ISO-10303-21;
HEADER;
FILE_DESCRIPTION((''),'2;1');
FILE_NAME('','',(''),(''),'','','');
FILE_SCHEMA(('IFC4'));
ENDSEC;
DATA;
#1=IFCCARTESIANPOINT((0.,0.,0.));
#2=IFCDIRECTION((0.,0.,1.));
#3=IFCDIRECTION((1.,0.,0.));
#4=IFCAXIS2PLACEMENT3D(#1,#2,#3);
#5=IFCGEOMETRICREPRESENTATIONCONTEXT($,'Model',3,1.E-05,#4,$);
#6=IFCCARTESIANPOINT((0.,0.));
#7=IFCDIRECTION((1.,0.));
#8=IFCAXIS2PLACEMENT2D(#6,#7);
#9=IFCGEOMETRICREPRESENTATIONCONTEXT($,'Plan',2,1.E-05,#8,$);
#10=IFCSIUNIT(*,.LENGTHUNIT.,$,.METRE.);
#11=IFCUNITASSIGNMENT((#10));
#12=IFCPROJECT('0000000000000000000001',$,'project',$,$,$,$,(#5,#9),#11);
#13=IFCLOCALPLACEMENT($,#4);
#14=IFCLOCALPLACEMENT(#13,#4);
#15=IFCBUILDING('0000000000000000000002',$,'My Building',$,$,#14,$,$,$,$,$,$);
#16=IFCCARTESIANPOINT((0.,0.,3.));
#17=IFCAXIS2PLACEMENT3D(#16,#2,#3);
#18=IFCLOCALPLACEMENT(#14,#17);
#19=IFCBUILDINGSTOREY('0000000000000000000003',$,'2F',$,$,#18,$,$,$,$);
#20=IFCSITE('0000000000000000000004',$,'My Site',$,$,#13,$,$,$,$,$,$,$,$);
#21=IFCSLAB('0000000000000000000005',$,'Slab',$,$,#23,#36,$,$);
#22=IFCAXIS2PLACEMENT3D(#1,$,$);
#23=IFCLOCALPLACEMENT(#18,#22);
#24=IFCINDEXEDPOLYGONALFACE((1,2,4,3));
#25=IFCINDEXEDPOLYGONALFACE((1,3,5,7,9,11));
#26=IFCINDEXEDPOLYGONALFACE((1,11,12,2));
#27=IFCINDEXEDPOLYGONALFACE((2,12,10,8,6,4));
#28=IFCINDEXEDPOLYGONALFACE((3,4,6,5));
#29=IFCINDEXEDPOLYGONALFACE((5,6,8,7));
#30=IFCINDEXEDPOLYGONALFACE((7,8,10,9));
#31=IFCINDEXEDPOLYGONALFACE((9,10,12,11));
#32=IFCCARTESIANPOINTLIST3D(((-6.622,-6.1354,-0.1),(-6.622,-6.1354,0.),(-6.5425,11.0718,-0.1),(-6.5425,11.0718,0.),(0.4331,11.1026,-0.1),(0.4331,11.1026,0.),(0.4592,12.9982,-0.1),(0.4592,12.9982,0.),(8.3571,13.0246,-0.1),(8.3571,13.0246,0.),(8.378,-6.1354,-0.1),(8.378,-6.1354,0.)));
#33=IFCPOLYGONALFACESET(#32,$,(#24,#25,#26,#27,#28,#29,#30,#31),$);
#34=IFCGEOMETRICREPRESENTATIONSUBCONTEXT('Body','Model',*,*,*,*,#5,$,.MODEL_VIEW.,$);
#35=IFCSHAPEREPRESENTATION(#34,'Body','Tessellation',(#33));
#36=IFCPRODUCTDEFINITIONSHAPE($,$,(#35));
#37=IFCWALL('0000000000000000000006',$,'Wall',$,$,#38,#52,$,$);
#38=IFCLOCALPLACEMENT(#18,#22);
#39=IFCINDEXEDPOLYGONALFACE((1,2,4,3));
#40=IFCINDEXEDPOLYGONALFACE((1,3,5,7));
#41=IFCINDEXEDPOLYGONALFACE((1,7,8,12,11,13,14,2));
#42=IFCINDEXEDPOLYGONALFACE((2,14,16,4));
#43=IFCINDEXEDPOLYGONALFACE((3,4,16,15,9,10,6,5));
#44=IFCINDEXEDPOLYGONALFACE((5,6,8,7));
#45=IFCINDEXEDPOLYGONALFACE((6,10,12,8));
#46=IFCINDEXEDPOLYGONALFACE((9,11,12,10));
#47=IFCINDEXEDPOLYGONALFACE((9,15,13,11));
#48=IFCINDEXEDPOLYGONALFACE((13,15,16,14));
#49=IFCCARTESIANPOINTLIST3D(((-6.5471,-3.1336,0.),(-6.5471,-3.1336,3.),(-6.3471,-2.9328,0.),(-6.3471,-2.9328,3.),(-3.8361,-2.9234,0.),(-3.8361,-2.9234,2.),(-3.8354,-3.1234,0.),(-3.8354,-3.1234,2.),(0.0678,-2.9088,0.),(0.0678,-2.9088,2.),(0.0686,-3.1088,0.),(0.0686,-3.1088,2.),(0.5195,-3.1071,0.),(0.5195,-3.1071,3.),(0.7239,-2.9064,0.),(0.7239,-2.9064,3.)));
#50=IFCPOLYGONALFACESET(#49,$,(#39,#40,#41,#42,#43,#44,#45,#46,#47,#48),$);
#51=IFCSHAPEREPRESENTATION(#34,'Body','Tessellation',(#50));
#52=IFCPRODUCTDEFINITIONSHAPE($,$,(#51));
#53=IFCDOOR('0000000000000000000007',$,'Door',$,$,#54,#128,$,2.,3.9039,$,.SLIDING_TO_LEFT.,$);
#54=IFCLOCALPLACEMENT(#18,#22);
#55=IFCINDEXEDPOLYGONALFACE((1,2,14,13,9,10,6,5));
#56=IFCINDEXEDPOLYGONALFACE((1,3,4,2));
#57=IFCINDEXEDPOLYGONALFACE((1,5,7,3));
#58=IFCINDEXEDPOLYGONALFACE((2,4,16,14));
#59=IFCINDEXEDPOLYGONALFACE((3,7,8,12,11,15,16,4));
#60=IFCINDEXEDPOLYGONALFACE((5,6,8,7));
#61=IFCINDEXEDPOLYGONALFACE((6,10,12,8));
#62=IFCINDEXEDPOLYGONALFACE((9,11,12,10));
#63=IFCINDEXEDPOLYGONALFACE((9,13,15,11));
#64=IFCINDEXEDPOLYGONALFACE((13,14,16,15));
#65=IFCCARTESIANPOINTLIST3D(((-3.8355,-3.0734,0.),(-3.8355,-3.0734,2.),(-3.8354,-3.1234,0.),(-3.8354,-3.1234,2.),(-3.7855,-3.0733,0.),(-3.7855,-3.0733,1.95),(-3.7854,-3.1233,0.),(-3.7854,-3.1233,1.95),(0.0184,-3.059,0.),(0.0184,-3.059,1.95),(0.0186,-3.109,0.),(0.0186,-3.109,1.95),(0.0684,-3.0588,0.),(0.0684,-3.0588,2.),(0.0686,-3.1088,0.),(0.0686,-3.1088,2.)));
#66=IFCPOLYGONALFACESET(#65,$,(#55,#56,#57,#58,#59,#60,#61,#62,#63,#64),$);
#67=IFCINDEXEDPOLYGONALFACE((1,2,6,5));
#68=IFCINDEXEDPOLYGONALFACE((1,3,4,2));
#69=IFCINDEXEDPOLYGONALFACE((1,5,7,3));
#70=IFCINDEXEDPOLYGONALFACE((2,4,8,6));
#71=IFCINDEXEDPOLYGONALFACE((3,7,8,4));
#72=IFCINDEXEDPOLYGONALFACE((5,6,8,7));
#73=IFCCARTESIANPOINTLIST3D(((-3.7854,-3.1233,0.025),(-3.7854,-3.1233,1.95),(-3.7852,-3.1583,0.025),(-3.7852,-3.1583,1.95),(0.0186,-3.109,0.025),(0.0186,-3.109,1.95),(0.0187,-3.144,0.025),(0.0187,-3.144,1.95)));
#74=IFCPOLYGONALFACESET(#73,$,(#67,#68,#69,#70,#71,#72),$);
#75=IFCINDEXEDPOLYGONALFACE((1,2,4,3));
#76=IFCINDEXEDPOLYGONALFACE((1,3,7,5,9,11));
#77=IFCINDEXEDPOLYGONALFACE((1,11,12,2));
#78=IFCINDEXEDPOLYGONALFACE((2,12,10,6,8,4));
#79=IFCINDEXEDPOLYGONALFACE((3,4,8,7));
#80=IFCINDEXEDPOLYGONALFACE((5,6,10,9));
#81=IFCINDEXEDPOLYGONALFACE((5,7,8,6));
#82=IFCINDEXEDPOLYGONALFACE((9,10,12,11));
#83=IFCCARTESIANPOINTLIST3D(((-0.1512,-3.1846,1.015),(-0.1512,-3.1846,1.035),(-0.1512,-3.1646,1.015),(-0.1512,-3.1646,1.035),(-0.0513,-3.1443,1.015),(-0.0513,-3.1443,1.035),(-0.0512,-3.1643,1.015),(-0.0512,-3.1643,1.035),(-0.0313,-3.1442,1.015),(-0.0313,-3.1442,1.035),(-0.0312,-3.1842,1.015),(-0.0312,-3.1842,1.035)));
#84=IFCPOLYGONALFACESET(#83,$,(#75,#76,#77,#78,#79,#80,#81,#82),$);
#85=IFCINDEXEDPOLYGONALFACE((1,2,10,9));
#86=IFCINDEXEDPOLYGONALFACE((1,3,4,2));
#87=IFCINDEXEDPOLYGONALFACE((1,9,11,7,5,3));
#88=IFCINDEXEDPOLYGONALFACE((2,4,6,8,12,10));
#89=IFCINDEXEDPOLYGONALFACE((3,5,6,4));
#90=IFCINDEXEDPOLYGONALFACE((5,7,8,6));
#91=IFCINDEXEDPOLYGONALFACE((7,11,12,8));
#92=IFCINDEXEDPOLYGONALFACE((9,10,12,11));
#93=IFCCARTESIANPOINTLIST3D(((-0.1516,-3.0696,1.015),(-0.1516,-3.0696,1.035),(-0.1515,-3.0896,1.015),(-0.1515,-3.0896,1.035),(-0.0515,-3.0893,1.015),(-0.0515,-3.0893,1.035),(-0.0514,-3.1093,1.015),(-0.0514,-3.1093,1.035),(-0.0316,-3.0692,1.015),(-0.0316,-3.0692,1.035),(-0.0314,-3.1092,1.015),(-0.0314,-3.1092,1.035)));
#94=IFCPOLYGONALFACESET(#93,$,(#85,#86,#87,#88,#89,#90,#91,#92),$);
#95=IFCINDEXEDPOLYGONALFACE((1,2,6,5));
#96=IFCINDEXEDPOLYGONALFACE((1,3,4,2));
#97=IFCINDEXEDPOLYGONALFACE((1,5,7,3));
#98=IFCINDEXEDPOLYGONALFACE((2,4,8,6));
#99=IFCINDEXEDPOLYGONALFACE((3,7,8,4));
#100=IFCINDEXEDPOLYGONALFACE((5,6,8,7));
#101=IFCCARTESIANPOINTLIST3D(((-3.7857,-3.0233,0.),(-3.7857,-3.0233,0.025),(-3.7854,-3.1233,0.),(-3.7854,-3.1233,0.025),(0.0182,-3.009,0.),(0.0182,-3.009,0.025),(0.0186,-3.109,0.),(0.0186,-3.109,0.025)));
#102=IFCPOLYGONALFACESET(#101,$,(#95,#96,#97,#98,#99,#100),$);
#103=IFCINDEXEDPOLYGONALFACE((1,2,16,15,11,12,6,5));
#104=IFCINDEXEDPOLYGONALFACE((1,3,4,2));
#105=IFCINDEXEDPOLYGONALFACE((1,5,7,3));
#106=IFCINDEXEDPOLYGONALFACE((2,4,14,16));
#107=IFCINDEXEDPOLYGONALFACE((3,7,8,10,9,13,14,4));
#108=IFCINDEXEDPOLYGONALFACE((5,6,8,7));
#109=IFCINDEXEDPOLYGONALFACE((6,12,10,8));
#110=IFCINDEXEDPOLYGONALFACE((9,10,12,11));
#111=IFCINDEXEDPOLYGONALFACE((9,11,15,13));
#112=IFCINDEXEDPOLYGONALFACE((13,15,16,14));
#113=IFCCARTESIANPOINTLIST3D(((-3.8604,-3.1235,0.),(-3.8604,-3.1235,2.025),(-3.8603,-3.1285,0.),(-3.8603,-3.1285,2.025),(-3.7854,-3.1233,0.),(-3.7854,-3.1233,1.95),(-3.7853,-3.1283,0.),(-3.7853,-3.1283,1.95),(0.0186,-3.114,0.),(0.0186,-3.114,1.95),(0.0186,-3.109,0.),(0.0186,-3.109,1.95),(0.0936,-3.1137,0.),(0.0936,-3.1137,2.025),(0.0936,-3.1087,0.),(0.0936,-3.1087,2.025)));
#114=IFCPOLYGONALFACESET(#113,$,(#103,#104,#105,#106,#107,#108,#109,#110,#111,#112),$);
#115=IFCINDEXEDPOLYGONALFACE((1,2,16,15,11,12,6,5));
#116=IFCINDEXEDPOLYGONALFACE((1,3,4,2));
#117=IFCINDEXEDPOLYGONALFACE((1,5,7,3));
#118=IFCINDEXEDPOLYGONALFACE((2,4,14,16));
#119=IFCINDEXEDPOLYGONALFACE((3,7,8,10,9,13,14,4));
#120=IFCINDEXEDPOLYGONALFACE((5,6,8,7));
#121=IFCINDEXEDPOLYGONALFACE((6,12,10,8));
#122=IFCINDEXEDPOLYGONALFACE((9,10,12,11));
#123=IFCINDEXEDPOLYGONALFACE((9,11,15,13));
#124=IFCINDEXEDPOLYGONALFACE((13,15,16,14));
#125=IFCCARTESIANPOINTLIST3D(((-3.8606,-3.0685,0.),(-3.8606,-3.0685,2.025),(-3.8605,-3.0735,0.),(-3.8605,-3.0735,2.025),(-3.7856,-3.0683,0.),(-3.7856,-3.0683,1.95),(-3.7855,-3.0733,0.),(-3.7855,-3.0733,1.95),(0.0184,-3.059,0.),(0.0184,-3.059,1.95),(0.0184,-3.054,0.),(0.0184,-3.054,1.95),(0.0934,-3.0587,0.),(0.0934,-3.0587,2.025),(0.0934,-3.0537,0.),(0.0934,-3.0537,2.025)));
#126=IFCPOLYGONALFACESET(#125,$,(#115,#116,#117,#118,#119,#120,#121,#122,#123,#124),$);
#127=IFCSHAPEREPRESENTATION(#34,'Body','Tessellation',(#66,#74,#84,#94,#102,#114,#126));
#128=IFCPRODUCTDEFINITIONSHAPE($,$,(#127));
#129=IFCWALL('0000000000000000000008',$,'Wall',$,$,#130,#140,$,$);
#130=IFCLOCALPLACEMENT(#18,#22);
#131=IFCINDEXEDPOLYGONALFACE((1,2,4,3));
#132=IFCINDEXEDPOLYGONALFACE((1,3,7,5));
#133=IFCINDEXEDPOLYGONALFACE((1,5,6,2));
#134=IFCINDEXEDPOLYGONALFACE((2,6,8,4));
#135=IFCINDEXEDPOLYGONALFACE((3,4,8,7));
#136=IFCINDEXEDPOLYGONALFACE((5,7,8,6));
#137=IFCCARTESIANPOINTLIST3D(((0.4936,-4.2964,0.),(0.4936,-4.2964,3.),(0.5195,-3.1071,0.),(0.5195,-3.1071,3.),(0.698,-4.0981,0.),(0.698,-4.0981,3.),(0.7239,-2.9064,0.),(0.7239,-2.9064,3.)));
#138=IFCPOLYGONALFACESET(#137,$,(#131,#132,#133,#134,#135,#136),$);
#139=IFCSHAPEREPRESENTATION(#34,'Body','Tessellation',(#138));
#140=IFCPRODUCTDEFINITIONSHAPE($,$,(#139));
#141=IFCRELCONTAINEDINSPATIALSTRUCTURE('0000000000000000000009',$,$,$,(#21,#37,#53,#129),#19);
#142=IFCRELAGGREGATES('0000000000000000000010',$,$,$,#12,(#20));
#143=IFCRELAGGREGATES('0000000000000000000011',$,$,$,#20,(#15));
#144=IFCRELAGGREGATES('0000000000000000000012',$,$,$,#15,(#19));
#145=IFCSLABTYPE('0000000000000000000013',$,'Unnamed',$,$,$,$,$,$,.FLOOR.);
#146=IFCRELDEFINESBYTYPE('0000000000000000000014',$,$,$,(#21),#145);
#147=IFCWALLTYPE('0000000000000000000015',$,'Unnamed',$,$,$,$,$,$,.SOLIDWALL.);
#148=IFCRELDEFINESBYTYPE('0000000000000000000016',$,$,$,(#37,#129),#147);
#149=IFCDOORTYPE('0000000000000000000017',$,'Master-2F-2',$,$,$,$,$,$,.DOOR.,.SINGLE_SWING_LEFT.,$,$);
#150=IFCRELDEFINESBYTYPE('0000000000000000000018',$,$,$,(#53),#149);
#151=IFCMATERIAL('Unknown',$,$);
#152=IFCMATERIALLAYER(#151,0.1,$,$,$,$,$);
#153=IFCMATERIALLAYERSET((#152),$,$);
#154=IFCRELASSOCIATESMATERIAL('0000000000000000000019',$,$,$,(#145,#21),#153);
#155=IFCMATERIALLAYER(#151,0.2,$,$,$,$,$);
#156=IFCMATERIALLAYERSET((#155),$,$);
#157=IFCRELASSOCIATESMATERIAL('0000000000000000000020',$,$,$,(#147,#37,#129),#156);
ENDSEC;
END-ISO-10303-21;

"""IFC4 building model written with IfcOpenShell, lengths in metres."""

from ifc_helpers import new_model, entity, si_unit, frame, origin_with_axes, origin_2d_with_axis, place, context, subcontext, project, spatial, line, indexed_curve, outline, extrude, shape, source, transform, mapped, material, layer, layer_set, layer_usage, type_object, type_shapes, element, fill, save


model = new_model("IFC4")

# Units and contexts
model_context = context("Model", 3, precision=1e-05, world=origin_with_axes())
plan_context = context("Plan", 2, precision=1e-05, world=origin_2d_with_axis())
body_context_1 = subcontext(model_context, "Body", "Model", "MODEL_VIEW")
body_context_2 = subcontext(plan_context, "Body", "Plan", "PLAN_VIEW")
ifc_project = project(units=[si_unit("LENGTHUNIT", "METRE")], contexts=[model_context, plan_context])

# Site, building, storey
site_placement = place(None, origin_with_axes())
site = spatial("IfcSite", under=ifc_project, at=site_placement, Name="My Site")
building_placement = place(site_placement, origin_with_axes())
building = spatial("IfcBuilding", under=site, at=building_placement, Name="My Building")
storey_placement = place(building_placement, frame((0.0, 0.0, 3.0), z_axis=(0.0, 0.0, 1.0), x_axis=(1.0, 0.0, 0.0)))
storey = spatial("IfcBuildingStorey", under=building, at=storey_placement, Name="2F")

# Slab
ifc_material = material(Name="Unknown")
ifc_layer_1 = layer(ifc_material, 0.1)
ifc_layer_set_1 = layer_set([ifc_layer_1])
ifc_layer_usage_1 = layer_usage(ifc_layer_set_1, "AXIS3", "POSITIVE", -0.1)
slab_type = type_object("IfcSlabType", Name="Unnamed", PredefinedType="FLOOR", material=ifc_layer_set_1)
slab_placement = place(storey_placement, frame((8.378, -6.1354, 0.0), z_axis=(0.0, 0.0, 1.0), x_axis=(1.0, 0.0, 0.0)))
element("IfcSlab", 1, at=slab_placement, inside=storey, type_object=slab_type, material=ifc_layer_usage_1, Name="Slab", context=body_context_1, shape_type="SweptSolid", body=[
    extrude(outline(indexed_curve([(0.0, 0.0), (-15.0, 0.0), (-14.9205, 17.2072), (-7.9449, 17.238), (-7.9188, 19.1336), (-0.0209, 19.1599), (0.0, 0.0)])), frame((0.0, 0.0, -0.1), z_axis=(0.0, 0.0, 1.0), x_axis=(1.0, 0.0, 0.0)), (0.0, 0.0, 1.0), 0.1),
])

# Wall, opening, door
ifc_layer_2 = layer(ifc_material, 0.2)
ifc_layer_set_2 = layer_set([ifc_layer_2])
ifc_layer_usage_2 = layer_usage(ifc_layer_set_2, "AXIS2", "POSITIVE", 0.0)
wall_type = type_object("IfcWallType", Name="Unnamed", PredefinedType="SOLIDWALL", material=ifc_layer_set_2)
wall_1_placement = place(storey_placement, frame((-6.5471, -3.1336, 0.0), z_axis=(0.0, 0.0, 1.0), x_axis=(0.999993, 0.003745, 0.0)))
wall_1 = element("IfcWall", 2, at=wall_1_placement, inside=storey, type_object=wall_type, material=ifc_layer_usage_2, Name="Wall", context=body_context_1, shape_type="SweptSolid", body=[
    extrude(outline(indexed_curve([(0.0, 0.0), (0.2008, 0.2), (7.2718, 0.2), (7.0666, 0.0)], segments=[line(1, 2, 3, 4, 1)])), origin_with_axes(), (0.0, 0.0, 1.0), 3.0),
])
shared_shape_1 = source(origin_with_axes(), body_context_1, "Body", "SweptSolid", [
    extrude(outline(indexed_curve([(0.0, 0.0), (3.9039, 0.0), (3.9039, 2.0), (0.0, 2.0)], segments=[line(1, 2, 3, 4, 1)])), frame((0.0, -0.6, 0.0), z_axis=(0.0, -1.0, 0.0), x_axis=(1.0, 0.0, 0.0)), (0.0, 0.0, -1.0), 1.2),
])
opening_1_placement = place(wall_1_placement, frame((2.7118, 0.0, 0.0), z_axis=(0.0, 0.0, 1.0), x_axis=(1.0, 0.0, 0.0)))
opening_1 = element("IfcOpeningElement", 3, at=opening_1_placement, cuts=wall_1, PredefinedType="OPENING", context=body_context_1, shape_type="MappedRepresentation", body=[
    mapped(shared_shape_1, transform((0.0, 0.0, 0.0), x_axis=(1.0, 0.0, 0.0), y_axis=(0.0, 1.0, 0.0), z_axis=(0.0, 0.0, 1.0), scale=1.0)),
])
door_type_1 = type_object("IfcDoorType", Name="Master-2F-2", OperationType="SINGLE_SWING_LEFT", PredefinedType="DOOR")
shared_shape_2 = source(origin_with_axes(), body_context_1, "Body", "SweptSolid", [
    extrude(outline(indexed_curve([(0.0, 0.0), (0.0, 2.0), (3.9039, 2.0), (3.9039, 0.0), (3.8539, 0.0), (3.8539, 1.95), (0.05, 1.95), (0.05, 0.0)], segments=[line(1, 2, 3, 4, 5, 6, 7, 8, 1)])), frame((0.0, 0.0, 0.0), z_axis=(0.0, -1.0, 0.0), x_axis=(1.0, 0.0, 0.0)), (0.0, 0.0, -1.0), 0.05),
    extrude(outline(indexed_curve([(0.0, 0.0), (3.8039, 0.0), (3.8039, 0.035), (0.0, 0.035)], segments=[line(1, 2, 3, 4, 1)])), frame((0.05, -0.035, 0.025), z_axis=(0.0, 0.0, 1.0), x_axis=(1.0, 0.0, 0.0)), (0.0, 0.0, 1.0), 1.925),
    extrude(outline(indexed_curve([(0.0, 0.0), (0.0, -0.04), (-0.12, -0.04), (-0.12, -0.02), (-0.02, -0.02), (-0.02, 0.0)], segments=[line(1, 2, 3, 4, 5, 6, 1)])), frame((3.8039, -0.035, 1.015), z_axis=(0.0, 0.0, 1.0), x_axis=(1.0, 0.0, 0.0)), (0.0, 0.0, 1.0), 0.02),
    extrude(outline(indexed_curve([(0.0, 0.0), (0.0, 0.04), (-0.12, 0.04), (-0.12, 0.02), (-0.02, 0.02), (-0.02, 0.0)], segments=[line(1, 2, 3, 4, 5, 6, 1)])), frame((3.8039, 0.0, 1.015), z_axis=(0.0, 0.0, 1.0), x_axis=(1.0, 0.0, 0.0)), (0.0, 0.0, 1.0), 0.02),
    extrude(outline(indexed_curve([(0.0, 0.0), (3.8039, 0.0), (3.8039, 0.1), (0.0, 0.1)], segments=[line(1, 2, 3, 4, 1)])), frame((0.05, 0.0, 0.0), z_axis=(0.0, 0.0, 1.0), x_axis=(1.0, 0.0, 0.0)), (0.0, 0.0, 1.0), 0.025),
    extrude(outline(indexed_curve([(0.0, 0.0), (0.0, 2.025), (3.9539, 2.025), (3.9539, 0.0), (3.8789, 0.0), (3.8789, 1.95), (0.075, 1.95), (0.075, 0.0)], segments=[line(1, 2, 3, 4, 5, 6, 7, 8, 1)])), frame((-0.025, -0.005, 0.0), z_axis=(0.0, -1.0, 0.0), x_axis=(1.0, 0.0, 0.0)), (0.0, 0.0, -1.0), 0.005),
    extrude(outline(indexed_curve([(0.0, 0.0), (0.0, 2.025), (3.9539, 2.025), (3.9539, 0.0), (3.8789, 0.0), (3.8789, 1.95), (0.075, 1.95), (0.075, 0.0)], segments=[line(1, 2, 3, 4, 5, 6, 7, 8, 1)])), frame((-0.025, 0.05, 0.0), z_axis=(0.0, -1.0, 0.0), x_axis=(1.0, 0.0, 0.0)), (0.0, 0.0, -1.0), 0.005),
])
shared_shape_3 = source(origin_with_axes(), body_context_2, "Body", "Curve2D", [
    entity("IfcIndexedPolyCurve", entity("IfcCartesianPointList2D", [[0.0, 0.0], [0.05, 0.0], [0.05, 0.05], [0.0, 0.05]]), [entity("IfcLineIndex", [1, 2, 3, 4, 1])]),
    entity("IfcIndexedPolyCurve", entity("IfcCartesianPointList2D", [[3.9039, 0.0], [3.8539, 0.0], [3.8539, 0.05], [3.9039, 0.05]]), [entity("IfcLineIndex", [1, 2, 3, 4, 1])]),
    entity("IfcIndexedPolyCurve", entity("IfcCartesianPointList2D", [[-1.852, -0.035], [1.952, -0.035], [1.952, 0.0], [-1.852, 0.0]]), [entity("IfcLineIndex", [1, 2, 3, 4, 1])]),
])
type_shapes(door_type_1, [shared_shape_2, shared_shape_3])
door_1_placement = place(opening_1_placement, frame((0.0, 0.0, 0.0), z_axis=(0.0, 0.0, 1.0), x_axis=(1.0, 0.0, 0.0)))
door_1 = element("IfcDoor", 4, at=door_1_placement, inside=storey, type_object=door_type_1, Name="Door", OperationType="SLIDING_TO_LEFT", OverallHeight=2.0, OverallWidth=3.9039, shapes=[
    shape(body_context_1, "Body", "MappedRepresentation", [mapped(shared_shape_2, transform((0.0, 0.0, 0.0), x_axis=(1.0, 0.0, 0.0), y_axis=(0.0, 1.0, 0.0), z_axis=(0.0, 0.0, 1.0), scale=1.0))]),
    shape(body_context_2, "Body", "MappedRepresentation", [mapped(shared_shape_3, transform((0.0, 0.0, 0.0), x_axis=(1.0, 0.0, 0.0), y_axis=(0.0, 1.0, 0.0), z_axis=(0.0, 0.0, 1.0), scale=1.0))]),
])
fill(opening_1, door_1)

# Wall
ifc_layer_usage_3 = layer_usage(ifc_layer_set_2, "AXIS2", "POSITIVE", 0.0)
wall_2_placement = place(storey_placement, frame((0.5195, -3.1071, 0.0), z_axis=(0.0, 0.0, 1.0), x_axis=(-0.021734, -0.999764, 0.0)))
element("IfcWall", 5, at=wall_2_placement, inside=storey, type_object=wall_type, material=ifc_layer_usage_3, Name="Wall", context=body_context_1, shape_type="SweptSolid", body=[
    extrude(outline(indexed_curve([(0.0, 0.0), (-0.2052, 0.2), (0.9869, 0.2), (1.1896, 0.0)], segments=[line(1, 2, 3, 4, 1)])), origin_with_axes(), (0.0, 0.0, 1.0), 3.0),
])

save(model, "model.ifc")
